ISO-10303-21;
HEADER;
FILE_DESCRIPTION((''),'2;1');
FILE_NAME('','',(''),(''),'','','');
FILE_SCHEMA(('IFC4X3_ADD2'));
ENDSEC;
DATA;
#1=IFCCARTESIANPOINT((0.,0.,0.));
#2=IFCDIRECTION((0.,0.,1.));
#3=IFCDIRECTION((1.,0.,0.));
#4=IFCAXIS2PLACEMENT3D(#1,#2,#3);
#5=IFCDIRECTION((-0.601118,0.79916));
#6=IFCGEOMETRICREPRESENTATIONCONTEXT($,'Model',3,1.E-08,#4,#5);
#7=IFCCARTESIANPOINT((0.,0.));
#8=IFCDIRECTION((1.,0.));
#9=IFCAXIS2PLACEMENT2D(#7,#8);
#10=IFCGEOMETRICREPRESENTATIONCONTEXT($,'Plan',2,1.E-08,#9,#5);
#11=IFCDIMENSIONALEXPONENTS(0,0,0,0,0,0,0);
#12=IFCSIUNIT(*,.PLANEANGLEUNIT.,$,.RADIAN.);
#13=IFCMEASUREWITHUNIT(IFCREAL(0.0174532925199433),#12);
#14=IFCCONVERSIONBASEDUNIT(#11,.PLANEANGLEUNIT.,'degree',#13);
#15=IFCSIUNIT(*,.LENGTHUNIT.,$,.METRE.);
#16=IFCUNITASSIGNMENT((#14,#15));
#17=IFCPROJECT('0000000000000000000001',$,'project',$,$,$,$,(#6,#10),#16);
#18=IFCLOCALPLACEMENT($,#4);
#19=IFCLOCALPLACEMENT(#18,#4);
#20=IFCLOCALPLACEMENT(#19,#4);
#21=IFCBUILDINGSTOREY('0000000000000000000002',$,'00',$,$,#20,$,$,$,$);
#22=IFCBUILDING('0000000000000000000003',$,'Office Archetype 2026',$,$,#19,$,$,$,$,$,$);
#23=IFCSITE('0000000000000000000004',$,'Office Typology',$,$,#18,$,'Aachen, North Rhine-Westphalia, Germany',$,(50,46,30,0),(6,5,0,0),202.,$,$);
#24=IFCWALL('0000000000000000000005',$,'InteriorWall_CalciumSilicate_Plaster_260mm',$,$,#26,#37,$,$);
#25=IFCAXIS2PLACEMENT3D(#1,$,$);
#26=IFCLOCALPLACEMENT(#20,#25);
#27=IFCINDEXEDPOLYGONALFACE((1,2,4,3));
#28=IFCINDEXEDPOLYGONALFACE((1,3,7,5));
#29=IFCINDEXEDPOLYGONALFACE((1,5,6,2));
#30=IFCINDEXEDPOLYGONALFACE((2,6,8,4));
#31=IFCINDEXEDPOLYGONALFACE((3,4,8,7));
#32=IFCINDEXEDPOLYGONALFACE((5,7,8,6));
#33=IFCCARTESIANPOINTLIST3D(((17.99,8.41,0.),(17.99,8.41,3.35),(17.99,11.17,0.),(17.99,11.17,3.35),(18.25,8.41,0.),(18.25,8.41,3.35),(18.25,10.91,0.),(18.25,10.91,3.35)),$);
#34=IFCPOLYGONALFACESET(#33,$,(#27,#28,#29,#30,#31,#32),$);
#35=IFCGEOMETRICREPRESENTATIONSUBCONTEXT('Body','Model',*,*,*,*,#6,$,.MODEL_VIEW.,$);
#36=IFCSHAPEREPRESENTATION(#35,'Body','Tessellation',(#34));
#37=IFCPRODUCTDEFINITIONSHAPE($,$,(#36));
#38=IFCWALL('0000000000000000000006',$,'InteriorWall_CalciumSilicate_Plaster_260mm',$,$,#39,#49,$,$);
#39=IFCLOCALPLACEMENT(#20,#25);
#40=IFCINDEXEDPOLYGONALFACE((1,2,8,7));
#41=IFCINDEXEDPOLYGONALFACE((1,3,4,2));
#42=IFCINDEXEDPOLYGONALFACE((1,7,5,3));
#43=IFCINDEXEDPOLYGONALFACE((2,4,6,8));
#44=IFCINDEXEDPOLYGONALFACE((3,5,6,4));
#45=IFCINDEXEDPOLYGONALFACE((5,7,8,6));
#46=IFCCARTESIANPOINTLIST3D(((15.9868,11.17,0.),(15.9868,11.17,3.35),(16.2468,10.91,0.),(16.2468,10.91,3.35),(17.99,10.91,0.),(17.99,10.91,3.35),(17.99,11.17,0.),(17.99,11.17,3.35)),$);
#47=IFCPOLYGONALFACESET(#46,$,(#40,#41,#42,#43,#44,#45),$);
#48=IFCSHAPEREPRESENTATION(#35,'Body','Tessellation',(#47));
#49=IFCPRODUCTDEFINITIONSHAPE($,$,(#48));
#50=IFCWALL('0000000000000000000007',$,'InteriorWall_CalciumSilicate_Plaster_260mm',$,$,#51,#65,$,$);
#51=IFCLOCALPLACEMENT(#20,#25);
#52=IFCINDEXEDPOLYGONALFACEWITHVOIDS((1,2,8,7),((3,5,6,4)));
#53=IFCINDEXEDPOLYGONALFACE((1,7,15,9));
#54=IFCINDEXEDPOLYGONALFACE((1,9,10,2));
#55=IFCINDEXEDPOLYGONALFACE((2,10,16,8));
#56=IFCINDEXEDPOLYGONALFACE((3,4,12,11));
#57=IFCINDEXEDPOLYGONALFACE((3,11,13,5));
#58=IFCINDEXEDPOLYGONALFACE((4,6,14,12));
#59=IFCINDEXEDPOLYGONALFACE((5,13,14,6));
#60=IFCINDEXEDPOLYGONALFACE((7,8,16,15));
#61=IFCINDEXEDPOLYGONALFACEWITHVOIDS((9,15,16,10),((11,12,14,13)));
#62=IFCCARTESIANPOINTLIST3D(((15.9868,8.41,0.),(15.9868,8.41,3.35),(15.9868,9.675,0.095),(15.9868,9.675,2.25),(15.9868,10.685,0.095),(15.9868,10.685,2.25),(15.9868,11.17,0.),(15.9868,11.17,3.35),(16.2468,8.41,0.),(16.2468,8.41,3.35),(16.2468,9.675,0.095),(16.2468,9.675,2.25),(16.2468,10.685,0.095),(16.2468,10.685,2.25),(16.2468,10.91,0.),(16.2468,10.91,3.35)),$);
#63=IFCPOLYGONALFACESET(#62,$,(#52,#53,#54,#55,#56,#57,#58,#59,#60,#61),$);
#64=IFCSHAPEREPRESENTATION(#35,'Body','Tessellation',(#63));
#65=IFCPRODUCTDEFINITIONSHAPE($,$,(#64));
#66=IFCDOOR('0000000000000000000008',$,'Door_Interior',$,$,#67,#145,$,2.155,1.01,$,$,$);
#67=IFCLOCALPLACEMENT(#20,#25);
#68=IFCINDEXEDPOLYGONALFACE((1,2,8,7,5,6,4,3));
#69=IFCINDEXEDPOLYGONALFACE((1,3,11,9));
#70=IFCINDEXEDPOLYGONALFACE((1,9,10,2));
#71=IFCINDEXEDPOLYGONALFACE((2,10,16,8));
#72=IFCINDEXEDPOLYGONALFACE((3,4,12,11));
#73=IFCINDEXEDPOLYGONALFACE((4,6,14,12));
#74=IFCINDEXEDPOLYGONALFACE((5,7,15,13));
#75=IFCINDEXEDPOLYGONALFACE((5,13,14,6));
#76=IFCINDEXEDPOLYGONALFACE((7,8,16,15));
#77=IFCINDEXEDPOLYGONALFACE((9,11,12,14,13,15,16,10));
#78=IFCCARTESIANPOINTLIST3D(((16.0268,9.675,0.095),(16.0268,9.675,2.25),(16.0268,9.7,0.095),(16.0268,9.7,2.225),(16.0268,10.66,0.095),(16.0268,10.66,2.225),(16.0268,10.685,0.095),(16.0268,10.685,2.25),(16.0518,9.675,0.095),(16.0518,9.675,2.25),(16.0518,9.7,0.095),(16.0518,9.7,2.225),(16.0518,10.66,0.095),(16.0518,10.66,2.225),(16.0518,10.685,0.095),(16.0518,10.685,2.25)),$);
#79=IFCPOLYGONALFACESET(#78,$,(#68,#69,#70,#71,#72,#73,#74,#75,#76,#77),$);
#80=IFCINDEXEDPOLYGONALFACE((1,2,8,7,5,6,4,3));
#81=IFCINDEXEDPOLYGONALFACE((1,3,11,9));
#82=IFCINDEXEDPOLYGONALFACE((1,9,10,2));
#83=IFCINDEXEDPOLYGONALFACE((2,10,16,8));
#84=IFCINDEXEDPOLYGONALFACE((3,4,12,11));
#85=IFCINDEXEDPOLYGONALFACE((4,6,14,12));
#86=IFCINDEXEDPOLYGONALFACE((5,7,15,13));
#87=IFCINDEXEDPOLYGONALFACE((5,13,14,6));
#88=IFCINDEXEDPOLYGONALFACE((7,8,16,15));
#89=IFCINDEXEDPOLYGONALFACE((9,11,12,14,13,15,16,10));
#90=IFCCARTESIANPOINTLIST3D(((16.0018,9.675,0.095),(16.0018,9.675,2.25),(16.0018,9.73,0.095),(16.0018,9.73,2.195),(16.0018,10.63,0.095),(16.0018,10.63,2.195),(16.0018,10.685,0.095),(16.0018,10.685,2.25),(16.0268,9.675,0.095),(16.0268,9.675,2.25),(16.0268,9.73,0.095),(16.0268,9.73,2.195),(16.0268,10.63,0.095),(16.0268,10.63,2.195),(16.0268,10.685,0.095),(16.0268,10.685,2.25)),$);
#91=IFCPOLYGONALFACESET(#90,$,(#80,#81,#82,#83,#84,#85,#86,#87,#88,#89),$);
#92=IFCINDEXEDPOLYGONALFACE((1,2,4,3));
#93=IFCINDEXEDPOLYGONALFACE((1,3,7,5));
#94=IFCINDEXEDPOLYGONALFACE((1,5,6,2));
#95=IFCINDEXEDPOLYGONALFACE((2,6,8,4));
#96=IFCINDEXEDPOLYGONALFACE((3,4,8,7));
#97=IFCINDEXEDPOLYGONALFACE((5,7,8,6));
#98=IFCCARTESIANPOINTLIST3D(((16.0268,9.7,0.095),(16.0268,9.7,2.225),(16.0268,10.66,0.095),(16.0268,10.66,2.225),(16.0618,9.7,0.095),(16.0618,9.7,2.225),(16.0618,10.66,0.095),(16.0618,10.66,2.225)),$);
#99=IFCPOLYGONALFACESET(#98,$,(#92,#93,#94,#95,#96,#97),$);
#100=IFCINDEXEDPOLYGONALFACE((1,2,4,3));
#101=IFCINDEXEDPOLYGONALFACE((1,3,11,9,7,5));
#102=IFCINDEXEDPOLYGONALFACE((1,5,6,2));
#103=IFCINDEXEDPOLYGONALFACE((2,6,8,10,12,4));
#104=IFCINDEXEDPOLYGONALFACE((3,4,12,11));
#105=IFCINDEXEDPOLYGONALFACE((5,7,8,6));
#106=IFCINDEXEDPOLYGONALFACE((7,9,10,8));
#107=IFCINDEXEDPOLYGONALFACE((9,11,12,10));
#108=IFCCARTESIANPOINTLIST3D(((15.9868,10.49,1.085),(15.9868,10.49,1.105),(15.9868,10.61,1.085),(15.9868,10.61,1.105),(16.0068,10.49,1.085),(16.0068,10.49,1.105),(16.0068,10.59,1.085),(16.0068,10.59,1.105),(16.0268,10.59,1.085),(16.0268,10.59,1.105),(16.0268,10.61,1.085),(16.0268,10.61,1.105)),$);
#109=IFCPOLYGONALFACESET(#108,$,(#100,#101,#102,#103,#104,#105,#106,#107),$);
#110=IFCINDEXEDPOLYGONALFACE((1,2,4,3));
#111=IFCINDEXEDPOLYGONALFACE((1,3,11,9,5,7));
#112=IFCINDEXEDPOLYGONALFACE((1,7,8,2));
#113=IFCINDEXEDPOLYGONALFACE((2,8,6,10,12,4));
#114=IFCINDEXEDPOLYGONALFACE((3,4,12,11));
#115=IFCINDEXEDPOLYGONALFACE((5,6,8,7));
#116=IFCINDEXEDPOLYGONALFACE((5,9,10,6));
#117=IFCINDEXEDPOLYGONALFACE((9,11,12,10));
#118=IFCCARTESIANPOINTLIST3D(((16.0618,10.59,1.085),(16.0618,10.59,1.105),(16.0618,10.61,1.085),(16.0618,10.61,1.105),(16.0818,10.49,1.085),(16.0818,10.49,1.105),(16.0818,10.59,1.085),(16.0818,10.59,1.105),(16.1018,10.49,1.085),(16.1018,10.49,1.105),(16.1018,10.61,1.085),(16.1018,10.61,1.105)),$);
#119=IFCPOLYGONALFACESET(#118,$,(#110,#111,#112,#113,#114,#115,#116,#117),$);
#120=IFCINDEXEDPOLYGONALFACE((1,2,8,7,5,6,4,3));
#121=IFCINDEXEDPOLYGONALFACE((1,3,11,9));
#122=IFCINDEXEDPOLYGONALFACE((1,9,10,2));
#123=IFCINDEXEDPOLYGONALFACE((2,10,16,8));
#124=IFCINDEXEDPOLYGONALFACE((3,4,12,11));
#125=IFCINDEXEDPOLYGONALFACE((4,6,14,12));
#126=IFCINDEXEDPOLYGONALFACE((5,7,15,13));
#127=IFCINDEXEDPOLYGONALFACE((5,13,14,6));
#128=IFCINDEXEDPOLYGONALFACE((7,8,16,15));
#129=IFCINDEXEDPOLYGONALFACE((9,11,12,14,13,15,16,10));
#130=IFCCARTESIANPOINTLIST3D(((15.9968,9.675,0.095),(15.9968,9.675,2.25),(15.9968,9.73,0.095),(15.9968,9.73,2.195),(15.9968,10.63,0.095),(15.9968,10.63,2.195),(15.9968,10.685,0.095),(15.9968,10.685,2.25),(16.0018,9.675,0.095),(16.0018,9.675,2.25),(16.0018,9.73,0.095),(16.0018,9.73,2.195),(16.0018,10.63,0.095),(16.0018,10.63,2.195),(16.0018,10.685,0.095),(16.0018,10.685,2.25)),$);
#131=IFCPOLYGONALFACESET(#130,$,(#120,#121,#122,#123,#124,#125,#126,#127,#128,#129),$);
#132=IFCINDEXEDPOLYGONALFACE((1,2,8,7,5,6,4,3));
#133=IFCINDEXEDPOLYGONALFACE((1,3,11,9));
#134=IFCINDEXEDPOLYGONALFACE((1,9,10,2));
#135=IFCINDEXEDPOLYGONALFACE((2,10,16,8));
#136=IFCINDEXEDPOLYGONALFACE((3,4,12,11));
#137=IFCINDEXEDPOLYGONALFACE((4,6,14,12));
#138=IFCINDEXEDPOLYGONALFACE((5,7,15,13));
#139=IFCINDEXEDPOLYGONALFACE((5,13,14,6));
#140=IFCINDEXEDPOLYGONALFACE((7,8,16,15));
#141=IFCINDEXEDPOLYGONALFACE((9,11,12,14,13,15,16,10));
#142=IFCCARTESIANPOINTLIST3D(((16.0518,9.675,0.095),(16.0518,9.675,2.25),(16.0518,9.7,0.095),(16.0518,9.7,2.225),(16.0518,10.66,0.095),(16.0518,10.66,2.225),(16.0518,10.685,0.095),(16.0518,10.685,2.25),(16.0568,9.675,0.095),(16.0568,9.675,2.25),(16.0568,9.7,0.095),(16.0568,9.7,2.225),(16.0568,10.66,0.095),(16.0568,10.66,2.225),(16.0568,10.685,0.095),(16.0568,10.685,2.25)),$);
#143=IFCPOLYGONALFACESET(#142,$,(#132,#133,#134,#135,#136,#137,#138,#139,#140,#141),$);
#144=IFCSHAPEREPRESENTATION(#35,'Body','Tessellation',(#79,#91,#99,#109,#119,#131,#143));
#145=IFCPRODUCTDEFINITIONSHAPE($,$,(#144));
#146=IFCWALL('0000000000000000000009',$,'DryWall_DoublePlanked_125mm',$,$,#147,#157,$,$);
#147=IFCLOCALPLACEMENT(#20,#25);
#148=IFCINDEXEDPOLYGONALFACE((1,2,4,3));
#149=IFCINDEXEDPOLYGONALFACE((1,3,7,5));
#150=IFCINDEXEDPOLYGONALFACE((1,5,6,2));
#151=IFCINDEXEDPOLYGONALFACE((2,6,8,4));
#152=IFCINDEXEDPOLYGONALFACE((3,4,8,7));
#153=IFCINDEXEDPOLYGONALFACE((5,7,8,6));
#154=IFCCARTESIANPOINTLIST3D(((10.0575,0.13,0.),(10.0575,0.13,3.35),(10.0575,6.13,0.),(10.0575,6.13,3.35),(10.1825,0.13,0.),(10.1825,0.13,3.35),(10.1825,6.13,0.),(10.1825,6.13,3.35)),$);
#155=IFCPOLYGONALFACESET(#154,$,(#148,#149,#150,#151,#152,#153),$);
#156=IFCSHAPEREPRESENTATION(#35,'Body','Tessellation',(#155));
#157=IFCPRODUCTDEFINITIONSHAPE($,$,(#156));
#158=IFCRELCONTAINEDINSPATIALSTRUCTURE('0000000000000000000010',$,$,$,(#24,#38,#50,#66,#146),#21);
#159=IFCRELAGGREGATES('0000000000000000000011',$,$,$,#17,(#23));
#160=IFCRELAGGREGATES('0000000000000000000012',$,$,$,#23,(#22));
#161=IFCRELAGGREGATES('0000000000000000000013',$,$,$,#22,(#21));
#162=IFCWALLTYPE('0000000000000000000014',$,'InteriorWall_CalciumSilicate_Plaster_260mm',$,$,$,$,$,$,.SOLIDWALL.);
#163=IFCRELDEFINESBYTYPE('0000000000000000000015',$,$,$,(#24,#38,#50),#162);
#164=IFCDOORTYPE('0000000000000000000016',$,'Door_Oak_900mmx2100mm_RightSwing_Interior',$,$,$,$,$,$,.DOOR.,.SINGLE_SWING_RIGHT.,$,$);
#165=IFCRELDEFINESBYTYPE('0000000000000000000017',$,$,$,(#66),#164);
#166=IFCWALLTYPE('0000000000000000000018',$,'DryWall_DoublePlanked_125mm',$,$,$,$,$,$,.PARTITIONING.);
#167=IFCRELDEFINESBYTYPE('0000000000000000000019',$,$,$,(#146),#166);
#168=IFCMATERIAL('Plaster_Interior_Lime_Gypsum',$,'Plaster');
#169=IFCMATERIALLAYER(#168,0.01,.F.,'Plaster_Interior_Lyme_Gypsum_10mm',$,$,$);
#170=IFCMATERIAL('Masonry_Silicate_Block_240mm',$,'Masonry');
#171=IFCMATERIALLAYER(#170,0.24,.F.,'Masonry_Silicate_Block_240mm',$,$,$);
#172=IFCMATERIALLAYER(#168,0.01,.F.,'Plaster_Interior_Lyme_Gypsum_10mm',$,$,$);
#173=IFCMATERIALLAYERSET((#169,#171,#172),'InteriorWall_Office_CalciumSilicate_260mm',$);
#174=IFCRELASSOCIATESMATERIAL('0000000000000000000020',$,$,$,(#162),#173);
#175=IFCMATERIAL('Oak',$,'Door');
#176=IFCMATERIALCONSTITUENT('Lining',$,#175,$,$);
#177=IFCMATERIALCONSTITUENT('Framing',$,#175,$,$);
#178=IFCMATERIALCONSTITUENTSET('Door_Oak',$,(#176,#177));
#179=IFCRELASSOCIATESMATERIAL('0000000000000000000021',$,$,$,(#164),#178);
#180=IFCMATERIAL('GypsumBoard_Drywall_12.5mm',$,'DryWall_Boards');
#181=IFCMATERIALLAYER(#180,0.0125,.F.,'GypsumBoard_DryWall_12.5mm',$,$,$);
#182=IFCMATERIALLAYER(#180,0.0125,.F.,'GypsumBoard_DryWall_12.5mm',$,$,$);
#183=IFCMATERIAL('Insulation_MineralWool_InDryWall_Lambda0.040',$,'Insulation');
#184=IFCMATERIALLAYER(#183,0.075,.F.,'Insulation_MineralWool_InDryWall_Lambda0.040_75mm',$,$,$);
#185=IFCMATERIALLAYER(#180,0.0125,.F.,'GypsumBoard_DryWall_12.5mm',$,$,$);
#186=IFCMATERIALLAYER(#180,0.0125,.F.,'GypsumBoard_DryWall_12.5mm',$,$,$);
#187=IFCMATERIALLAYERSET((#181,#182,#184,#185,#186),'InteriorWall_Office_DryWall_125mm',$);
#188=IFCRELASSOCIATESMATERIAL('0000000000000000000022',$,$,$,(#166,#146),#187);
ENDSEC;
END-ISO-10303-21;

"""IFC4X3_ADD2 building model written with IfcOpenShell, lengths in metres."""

from ifc_helpers import new_model, entity, si_unit, converted_unit, direction, frame, origin_with_axes, origin_2d_with_axis, place, context, subcontext, project, spatial, line, indexed_curve, outline, extrude, source, transform, mapped, material, layer, layer_set, layer_usage, constituent, constituent_set, type_object, type_shapes, element, fill, save


model = new_model("IFC4X3_ADD2")

# Units and contexts
model_context = context("Model", 3, precision=1e-08, world=origin_with_axes(), true_north=direction((-0.601118, 0.79916)))
plan_context = context("Plan", 2, precision=1e-08, world=origin_2d_with_axis(), true_north=direction((-0.601118, 0.79916)))
body_context = subcontext(model_context, "Body", "Model", "MODEL_VIEW")
ifc_project = project(units=[converted_unit("PLANEANGLEUNIT", "degree", entity("IfcReal", 0.0174532925199433), si_unit("PLANEANGLEUNIT", "RADIAN"), dimensions=[0, 0, 0, 0, 0, 0, 0]), si_unit("LENGTHUNIT", "METRE")], contexts=[model_context, plan_context])

# Site, building, storey
site_placement = place(None, origin_with_axes())
site = spatial("IfcSite", under=ifc_project, at=site_placement, Name="Office Typology", LongName="Aachen, North Rhine-Westphalia, Germany", RefLatitude=(50, 46, 30, 0), RefLongitude=(6, 5, 0, 0), RefElevation=202.0)
building_placement = place(site_placement, origin_with_axes())
building = spatial("IfcBuilding", under=site, at=building_placement, Name="Office Archetype 2026")
storey_placement = place(building_placement, origin_with_axes())
storey = spatial("IfcBuildingStorey", under=building, at=storey_placement, Name="00")

# Walls
ifc_material_1 = material(Name="Plaster_Interior_Lime_Gypsum", Category="Plaster")
ifc_layer_1 = layer(ifc_material_1, 0.01, ventilated=False, Name="Plaster_Interior_Lyme_Gypsum_10mm")
ifc_material_2 = material(Name="Masonry_Silicate_Block_240mm", Category="Masonry")
ifc_layer_2 = layer(ifc_material_2, 0.24, ventilated=False, Name="Masonry_Silicate_Block_240mm")
ifc_layer_3 = layer(ifc_material_1, 0.01, ventilated=False, Name="Plaster_Interior_Lyme_Gypsum_10mm")
ifc_layer_set_1 = layer_set([ifc_layer_1, ifc_layer_2, ifc_layer_3], Name="InteriorWall_Office_CalciumSilicate_260mm")
wall_type_1 = type_object("IfcWallType", Name="InteriorWall_CalciumSilicate_Plaster_260mm", PredefinedType="SOLIDWALL", material=ifc_layer_set_1)
wall_1_placement = place(storey_placement, frame((17.99, 11.17, 0.0), z_axis=(0.0, 0.0, 1.0), x_axis=(0.0, -1.0, 0.0)))
element("IfcWall", 1, at=wall_1_placement, inside=storey, type_object=wall_type_1, Name="InteriorWall_CalciumSilicate_Plaster_260mm", context=body_context, shape_type="SweptSolid", body=[
    extrude(outline(indexed_curve([(0.0, 0.0), (0.26, 0.26), (2.76, 0.26), (2.76, 0.0)], segments=[line(1, 2, 3, 4, 1)])), origin_with_axes(), (0.0, 0.0, 1.0), 3.35),
])
wall_2_placement = place(storey_placement, frame((17.99, 11.17, 0.0), z_axis=(0.0, 0.0, 1.0), x_axis=(-1.0, 0.0, 0.0)))
element("IfcWall", 2, at=wall_2_placement, inside=storey, type_object=wall_type_1, Name="InteriorWall_CalciumSilicate_Plaster_260mm", context=body_context, shape_type="SweptSolid", body=[
    extrude(outline(indexed_curve([(0.0, 0.0), (0.0, 0.26), (1.7432, 0.26), (2.0032, 0.0)], segments=[line(1, 2, 3, 4, 1)])), origin_with_axes(), (0.0, 0.0, 1.0), 3.35),
])

# Wall, opening, door
wall_3_placement = place(storey_placement, frame((15.9868, 11.17, 0.0), z_axis=(0.0, 0.0, 1.0), x_axis=(0.0, -1.0, 0.0)))
wall_3 = element("IfcWall", 3, at=wall_3_placement, inside=storey, type_object=wall_type_1, Name="InteriorWall_CalciumSilicate_Plaster_260mm", context=body_context, shape_type="SweptSolid", body=[
    extrude(outline(indexed_curve([(0.0, 0.0), (0.26, 0.26), (2.76, 0.26), (2.76, 0.0)], segments=[line(1, 2, 3, 4, 1)])), origin_with_axes(), (0.0, 0.0, 1.0), 3.35),
])
shared_shape_1 = source(origin_with_axes(), body_context, "Body", "SweptSolid", [
    extrude(outline(indexed_curve([(0.0, 2.155), (1.01, 2.155), (1.01, 0.0), (0.0, 0.0), (0.0, 2.155)])), frame((0.0, 0.0, 0.0), z_axis=(0.0, -1.0, 0.0), x_axis=(1.0, 0.0, 0.0)), (0.0, 0.0, -1.0), 0.26),
])
opening_1_placement = place(wall_3_placement, frame((0.485, 0.0, 0.095), z_axis=(0.0, 0.0, 1.0), x_axis=(1.0, 0.0, 0.0)))
opening_1 = element("IfcOpeningElement", 4, at=opening_1_placement, cuts=wall_3, PredefinedType="OPENING", context=body_context, shape_type="MappedRepresentation", body=[
    mapped(shared_shape_1, transform((0.0, 0.0, 0.0), x_axis=(1.0, 0.0, 0.0), y_axis=(0.0, 1.0, 0.0), z_axis=(0.0, 0.0, 1.0), scale=1.0)),
])
ifc_material_3 = material(Name="Oak", Category="Door")
ifc_constituent_1 = constituent(ifc_material_3, Name="Lining")
ifc_constituent_2 = constituent(ifc_material_3, Name="Framing")
ifc_constituent_set_1 = constituent_set(constituents=[ifc_constituent_1, ifc_constituent_2], Name="Door_Oak")
door_type_1 = type_object("IfcDoorType", Name="Door_Oak_900mmx2100mm_RightSwing_Interior", OperationType="SINGLE_SWING_RIGHT", PredefinedType="DOOR", material=ifc_constituent_set_1)
shared_shape_2 = source(origin_with_axes(), body_context, "Body", "SweptSolid", [
    extrude(outline(indexed_curve([(0.0, 0.0), (0.0, 2.155), (1.01, 2.155), (1.01, 0.0), (0.985, 0.0), (0.985, 2.13), (0.025, 2.13), (0.025, 0.0)], segments=[line(1, 2, 3, 4, 5, 6, 7, 8, 1)])), frame((0.0, 0.025, 0.0), z_axis=(0.0, -1.0, 0.0), x_axis=(1.0, 0.0, 0.0)), (0.0, 0.0, -1.0), 0.025),
    extrude(outline(indexed_curve([(0.0, 0.0), (0.0, 2.155), (1.01, 2.155), (1.01, 0.0), (0.955, 0.0), (0.955, 2.1), (0.055, 2.1), (0.055, 0.0)], segments=[line(1, 2, 3, 4, 5, 6, 7, 8, 1)])), frame((0.0, 0.0, 0.0), z_axis=(0.0, -1.0, 0.0), x_axis=(1.0, 0.0, 0.0)), (0.0, 0.0, -1.0), 0.025),
    extrude(outline(indexed_curve([(0.0, 0.0), (0.96, 0.0), (0.96, 0.035), (0.0, 0.035)], segments=[line(1, 2, 3, 4, 1)])), frame((0.025, 0.025, 0.0), z_axis=(0.0, 0.0, 1.0), x_axis=(1.0, 0.0, 0.0)), (0.0, 0.0, 1.0), 2.13),
    extrude(outline(indexed_curve([(0.0, 0.0), (0.0, -0.04), (0.12, -0.04), (0.12, -0.02), (0.02, -0.02), (0.02, 0.0)], segments=[line(1, 2, 3, 4, 5, 6, 1)])), frame((0.075, 0.025, 0.99), z_axis=(0.0, 0.0, 1.0), x_axis=(1.0, 0.0, 0.0)), (0.0, 0.0, 1.0), 0.02),
    extrude(outline(indexed_curve([(0.0, 0.0), (0.0, 0.04), (0.12, 0.04), (0.12, 0.02), (0.02, 0.02), (0.02, 0.0)], segments=[line(1, 2, 3, 4, 5, 6, 1)])), frame((0.075, 0.06, 0.99), z_axis=(0.0, 0.0, 1.0), x_axis=(1.0, 0.0, 0.0)), (0.0, 0.0, 1.0), 0.02),
    extrude(outline(indexed_curve([(0.0, 0.0), (0.0, 2.155), (1.01, 2.155), (1.01, 0.0), (0.955, 0.0), (0.955, 2.1), (0.055, 2.1), (0.055, 0.0)], segments=[line(1, 2, 3, 4, 5, 6, 7, 8, 1)])), frame((0.0, -0.005, 0.0), z_axis=(0.0, -1.0, 0.0), x_axis=(1.0, 0.0, 0.0)), (0.0, 0.0, -1.0), 0.005),
    extrude(outline(indexed_curve([(0.0, 0.0), (0.0, 2.155), (1.01, 2.155), (1.01, 0.0), (0.985, 0.0), (0.985, 2.13), (0.025, 2.13), (0.025, 0.0)], segments=[line(1, 2, 3, 4, 5, 6, 7, 8, 1)])), frame((0.0, 0.05, 0.0), z_axis=(0.0, -1.0, 0.0), x_axis=(1.0, 0.0, 0.0)), (0.0, 0.0, -1.0), 0.005),
])
type_shapes(door_type_1, [shared_shape_2])
door_1_placement = place(opening_1_placement, frame((0.0, 0.015, 0.0), z_axis=(0.0, 0.0, 1.0), x_axis=(1.0, 0.0, 0.0)))
door_1 = element("IfcDoor", 5, at=door_1_placement, inside=storey, type_object=door_type_1, Name="Door_Interior", OverallHeight=2.155, OverallWidth=1.01, context=body_context, shape_type="MappedRepresentation", body=[
    mapped(shared_shape_2, transform((0.0, 0.0, 0.0), x_axis=(1.0, 0.0, 0.0), y_axis=(0.0, 1.0, 0.0), z_axis=(0.0, 0.0, 1.0), scale=1.0)),
])
fill(opening_1, door_1)

# Wall
ifc_material_4 = material(Name="GypsumBoard_Drywall_12.5mm", Category="DryWall_Boards")
ifc_layer_4 = layer(ifc_material_4, 0.0125, ventilated=False, Name="GypsumBoard_DryWall_12.5mm")
ifc_layer_5 = layer(ifc_material_4, 0.0125, ventilated=False, Name="GypsumBoard_DryWall_12.5mm")
ifc_material_5 = material(Name="Insulation_MineralWool_InDryWall_Lambda0.040", Category="Insulation")
ifc_layer_6 = layer(ifc_material_5, 0.075, ventilated=False, Name="Insulation_MineralWool_InDryWall_Lambda0.040_75mm")
ifc_layer_7 = layer(ifc_material_4, 0.0125, ventilated=False, Name="GypsumBoard_DryWall_12.5mm")
ifc_layer_8 = layer(ifc_material_4, 0.0125, ventilated=False, Name="GypsumBoard_DryWall_12.5mm")
ifc_layer_set_2 = layer_set([ifc_layer_4, ifc_layer_5, ifc_layer_6, ifc_layer_7, ifc_layer_8], Name="InteriorWall_Office_DryWall_125mm")
wall_type_2 = type_object("IfcWallType", Name="DryWall_DoublePlanked_125mm", PredefinedType="PARTITIONING", material=ifc_layer_set_2)
ifc_layer_usage_1 = layer_usage(ifc_layer_set_2, "AXIS2", "POSITIVE", 0.0)
wall_4_placement = place(storey_placement, frame((10.0575, 6.13, 0.0), z_axis=(0.0, 0.0, 1.0), x_axis=(0.0, -1.0, 0.0)))
element("IfcWall", 6, at=wall_4_placement, inside=storey, type_object=wall_type_2, material=ifc_layer_usage_1, Name="DryWall_DoublePlanked_125mm", context=body_context, shape_type="SweptSolid", body=[
    extrude(outline(indexed_curve([(0.0, 0.0), (0.0, 0.125), (6.0, 0.125), (6.0, 0.0)], segments=[line(1, 2, 3, 4, 1)])), origin_with_axes(), (0.0, 0.0, 1.0), 3.35),
])

save(model, "model.ifc")
